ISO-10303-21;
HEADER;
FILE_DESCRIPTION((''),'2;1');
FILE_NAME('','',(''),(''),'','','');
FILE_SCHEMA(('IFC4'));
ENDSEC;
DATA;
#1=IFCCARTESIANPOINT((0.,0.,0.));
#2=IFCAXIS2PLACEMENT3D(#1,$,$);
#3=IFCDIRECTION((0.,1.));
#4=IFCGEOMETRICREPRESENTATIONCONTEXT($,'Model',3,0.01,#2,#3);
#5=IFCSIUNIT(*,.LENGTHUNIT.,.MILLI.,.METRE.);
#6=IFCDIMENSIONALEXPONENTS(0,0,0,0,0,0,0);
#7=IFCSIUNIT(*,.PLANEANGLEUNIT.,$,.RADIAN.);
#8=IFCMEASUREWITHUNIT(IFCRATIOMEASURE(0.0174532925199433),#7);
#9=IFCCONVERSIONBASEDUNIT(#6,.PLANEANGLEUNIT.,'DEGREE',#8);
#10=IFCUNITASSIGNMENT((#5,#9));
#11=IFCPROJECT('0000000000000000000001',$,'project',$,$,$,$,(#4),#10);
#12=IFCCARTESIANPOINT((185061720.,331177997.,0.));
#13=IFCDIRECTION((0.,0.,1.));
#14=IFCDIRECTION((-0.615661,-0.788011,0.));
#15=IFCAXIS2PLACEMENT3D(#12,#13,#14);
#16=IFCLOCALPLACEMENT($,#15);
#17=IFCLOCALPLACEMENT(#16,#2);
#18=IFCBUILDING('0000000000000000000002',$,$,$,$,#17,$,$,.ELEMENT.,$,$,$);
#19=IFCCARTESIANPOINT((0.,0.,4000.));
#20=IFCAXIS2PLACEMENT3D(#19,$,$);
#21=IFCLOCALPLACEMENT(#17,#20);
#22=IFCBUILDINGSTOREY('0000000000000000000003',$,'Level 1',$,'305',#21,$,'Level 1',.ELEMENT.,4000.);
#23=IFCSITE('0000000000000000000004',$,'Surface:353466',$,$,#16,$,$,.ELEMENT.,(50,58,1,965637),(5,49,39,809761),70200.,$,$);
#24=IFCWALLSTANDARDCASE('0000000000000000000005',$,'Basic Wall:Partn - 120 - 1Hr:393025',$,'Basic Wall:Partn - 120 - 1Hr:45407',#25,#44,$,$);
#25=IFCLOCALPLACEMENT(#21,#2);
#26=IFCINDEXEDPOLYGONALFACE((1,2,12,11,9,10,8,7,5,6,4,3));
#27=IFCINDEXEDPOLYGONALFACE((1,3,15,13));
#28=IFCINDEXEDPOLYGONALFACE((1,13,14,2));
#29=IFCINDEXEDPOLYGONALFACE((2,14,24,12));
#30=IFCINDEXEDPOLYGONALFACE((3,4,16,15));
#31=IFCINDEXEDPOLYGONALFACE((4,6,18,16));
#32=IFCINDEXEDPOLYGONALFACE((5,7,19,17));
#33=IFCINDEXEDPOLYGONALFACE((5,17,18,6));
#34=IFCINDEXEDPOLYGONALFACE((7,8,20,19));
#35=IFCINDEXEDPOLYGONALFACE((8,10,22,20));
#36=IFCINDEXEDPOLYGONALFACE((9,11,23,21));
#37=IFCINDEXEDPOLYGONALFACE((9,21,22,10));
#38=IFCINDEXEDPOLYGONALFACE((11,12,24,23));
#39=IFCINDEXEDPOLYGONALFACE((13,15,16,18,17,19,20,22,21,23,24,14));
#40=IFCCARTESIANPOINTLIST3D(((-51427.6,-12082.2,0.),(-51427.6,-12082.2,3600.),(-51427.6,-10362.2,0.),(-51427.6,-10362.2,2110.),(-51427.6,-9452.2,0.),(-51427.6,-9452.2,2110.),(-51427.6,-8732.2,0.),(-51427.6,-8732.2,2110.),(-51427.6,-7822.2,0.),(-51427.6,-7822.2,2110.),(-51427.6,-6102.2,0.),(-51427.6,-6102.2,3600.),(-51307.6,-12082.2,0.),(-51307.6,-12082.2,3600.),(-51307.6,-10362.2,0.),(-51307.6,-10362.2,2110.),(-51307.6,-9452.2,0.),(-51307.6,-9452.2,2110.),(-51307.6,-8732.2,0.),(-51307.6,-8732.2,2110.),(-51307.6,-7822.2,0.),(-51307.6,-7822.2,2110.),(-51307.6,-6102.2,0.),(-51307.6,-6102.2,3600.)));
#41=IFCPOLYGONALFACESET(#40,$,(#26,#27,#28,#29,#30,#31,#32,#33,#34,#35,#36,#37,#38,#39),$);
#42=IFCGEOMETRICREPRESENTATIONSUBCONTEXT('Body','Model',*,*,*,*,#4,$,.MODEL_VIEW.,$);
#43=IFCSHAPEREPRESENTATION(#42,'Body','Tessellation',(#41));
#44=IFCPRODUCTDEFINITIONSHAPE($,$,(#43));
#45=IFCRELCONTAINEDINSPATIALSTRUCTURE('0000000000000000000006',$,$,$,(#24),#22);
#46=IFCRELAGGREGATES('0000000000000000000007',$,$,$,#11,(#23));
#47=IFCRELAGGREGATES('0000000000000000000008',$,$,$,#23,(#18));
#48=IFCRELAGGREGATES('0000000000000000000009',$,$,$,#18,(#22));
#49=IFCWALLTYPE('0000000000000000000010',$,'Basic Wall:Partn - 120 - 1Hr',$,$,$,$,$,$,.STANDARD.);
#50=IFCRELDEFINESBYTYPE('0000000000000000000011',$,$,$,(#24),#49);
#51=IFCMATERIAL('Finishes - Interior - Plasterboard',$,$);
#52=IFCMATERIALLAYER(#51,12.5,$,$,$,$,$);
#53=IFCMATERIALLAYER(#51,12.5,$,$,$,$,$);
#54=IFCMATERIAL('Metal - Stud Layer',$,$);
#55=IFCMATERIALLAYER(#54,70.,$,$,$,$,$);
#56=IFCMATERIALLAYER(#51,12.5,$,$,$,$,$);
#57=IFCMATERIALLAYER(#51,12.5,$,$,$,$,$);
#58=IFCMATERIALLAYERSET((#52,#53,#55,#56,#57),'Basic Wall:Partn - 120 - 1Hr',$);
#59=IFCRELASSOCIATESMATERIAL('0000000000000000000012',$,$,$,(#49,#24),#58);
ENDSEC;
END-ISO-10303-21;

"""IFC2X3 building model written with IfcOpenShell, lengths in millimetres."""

from ifc_helpers import new_model, entity, si_unit, converted_unit, direction, frame, frame_2d, origin, place, context, subcontext, project, spatial, polyline, rectangle, extrude, clip, bounded_halfspace, material, layer, layer_set, layer_usage, type_object, element, save


model = new_model("IFC2X3")

# Units and contexts
model_context = context("Model", 3, precision=0.01, world=origin(), true_north=direction((0.0, 1.0)))
body_context = subcontext(model_context, "Body", "Model", "MODEL_VIEW")
ifc_project = project(units=[si_unit("LENGTHUNIT", "METRE", prefix="MILLI"), converted_unit("PLANEANGLEUNIT", "DEGREE", entity("IfcRatioMeasure", 0.0174532925199433), si_unit("PLANEANGLEUNIT", "RADIAN"), dimensions=[0, 0, 0, 0, 0, 0, 0])], contexts=[model_context])

# Site, building, storey
site_placement = place(None, frame((185061720.0, 331177997.0, 0.0), z_axis=(0.0, 0.0, 1.0), x_axis=(-0.615661, -0.788011, 0.0)))
site = spatial("IfcSite", under=ifc_project, at=site_placement, Name="Surface:353466", CompositionType="ELEMENT", RefLatitude=(50, 58, 1, 965637), RefLongitude=(5, 49, 39, 809761), RefElevation=70200.0)
building_placement = place(site_placement, origin())
building = spatial("IfcBuilding", under=site, at=building_placement, CompositionType="ELEMENT")
storey_placement = place(building_placement, frame((0.0, 0.0, 4000.0)))
storey = spatial("IfcBuildingStorey", under=building, at=storey_placement, Name="Level 1", ObjectType="305", LongName="Level 1", CompositionType="ELEMENT", Elevation=4000.0)

# Shared definitions
ifc_material_1 = material(Name="Finishes - Interior - Plasterboard")

# Shared definitions
ifc_layer_1 = layer(ifc_material_1, 12.5)
ifc_layer_2 = layer(ifc_material_1, 12.5)
ifc_material_2 = material(Name="Metal - Stud Layer")
ifc_layer_3 = layer(ifc_material_2, 70.0)
ifc_layer_4 = layer(ifc_material_1, 12.5)
ifc_layer_5 = layer(ifc_material_1, 12.5)
ifc_layer_set_1 = layer_set([ifc_layer_1, ifc_layer_2, ifc_layer_3, ifc_layer_4, ifc_layer_5], Name="Basic Wall:Partn - 120 - 1Hr")
wall_type_1 = type_object("IfcWallType", Name="Basic Wall:Partn - 120 - 1Hr", PredefinedType="STANDARD", material=ifc_layer_set_1)

# Wall, openings
ifc_layer_usage_1 = layer_usage(ifc_layer_set_1, "AXIS2", "POSITIVE", -60.0)
wall_1_placement = place(storey_placement, frame((-51367.6, -12082.2, 0.0), z_axis=(0.0, 0.0, 1.0), x_axis=(0.0, 1.0, 0.0)))
wall_1 = element("IfcWallStandardCase", 1, at=wall_1_placement, inside=storey, type_object=wall_type_1, material=ifc_layer_usage_1, Name="Basic Wall:Partn - 120 - 1Hr:393025", ObjectType="Basic Wall:Partn - 120 - 1Hr:45407", context=body_context, shape_type="Clipping", body=[
    clip(extrude(rectangle(XDim=5980.0, YDim=120.0, at=frame_2d((2990.0, 0.0), x_axis=(-1.0, 0.0))), origin(), (0.0, 0.0, 1.0), 3600.0), bounded_halfspace(frame((0.0, -60.0, 3600.0), z_axis=(0.0, 0.0, -1.0), x_axis=(0.0, -1.0, 0.0)), True, frame((0.0, -60.0, 3600.0)), polyline([(0.0, 0.0), (5980.0, 0.0), (5980.0, 120.0), (0.0, 120.0), (0.0, 0.0)]))),
])
opening_1_placement = place(wall_1_placement, origin())
element("IfcOpeningElement", 2, at=opening_1_placement, cuts=wall_1, ObjectType="Opening", context=body_context, shape_type="SweptSolid", body=[
    extrude(rectangle(XDim=2110.0, YDim=910.0, at=frame_2d((0.0, 0.0), x_axis=(1.0, 0.0))), frame((3805.0, -1584.0, 1055.0), z_axis=(0.0, 1.0, 0.0), x_axis=(0.0, 0.0, 1.0)), (0.0, 0.0, 1.0), 3048.0),
])
opening_2_placement = place(wall_1_placement, origin())
element("IfcOpeningElement", 3, at=opening_2_placement, cuts=wall_1, ObjectType="Opening", context=body_context, shape_type="SweptSolid", body=[
    extrude(rectangle(XDim=2110.0, YDim=910.0, at=frame_2d((0.0, 0.0), x_axis=(0.0, 1.0))), frame((2175.0, -1584.0, 1055.0), z_axis=(0.0, 1.0, 0.0), x_axis=(-1.0, 0.0, 0.0)), (0.0, 0.0, 1.0), 3048.0),
])
opening_3_placement = place(wall_1_placement, frame((3350.0, -60.0, 0.0)))
element("IfcOpeningElement", 4, at=opening_3_placement, cuts=wall_1, ObjectType="Opening", context=body_context, shape_type="SweptSolid", body=[
    extrude(rectangle(XDim=2110.0, YDim=910.0, at=frame_2d((1055.0, 455.0), x_axis=(1.0, 0.0))), frame((0.0, 0.0, 0.0), z_axis=(0.0, 1.0, 0.0), x_axis=(0.0, 0.0, 1.0)), (0.0, 0.0, 1.0), 120.0),
])
opening_4_placement = place(wall_1_placement, frame((1720.0, -60.0, 0.0)))
element("IfcOpeningElement", 5, at=opening_4_placement, cuts=wall_1, ObjectType="Opening", context=body_context, shape_type="SweptSolid", body=[
    extrude(rectangle(XDim=2110.0, YDim=910.0, at=frame_2d((1055.0, 455.0), x_axis=(1.0, 0.0))), frame((0.0, 0.0, 0.0), z_axis=(0.0, 1.0, 0.0), x_axis=(0.0, 0.0, 1.0)), (0.0, 0.0, 1.0), 120.0),
])

save(model, "model.ifc")
